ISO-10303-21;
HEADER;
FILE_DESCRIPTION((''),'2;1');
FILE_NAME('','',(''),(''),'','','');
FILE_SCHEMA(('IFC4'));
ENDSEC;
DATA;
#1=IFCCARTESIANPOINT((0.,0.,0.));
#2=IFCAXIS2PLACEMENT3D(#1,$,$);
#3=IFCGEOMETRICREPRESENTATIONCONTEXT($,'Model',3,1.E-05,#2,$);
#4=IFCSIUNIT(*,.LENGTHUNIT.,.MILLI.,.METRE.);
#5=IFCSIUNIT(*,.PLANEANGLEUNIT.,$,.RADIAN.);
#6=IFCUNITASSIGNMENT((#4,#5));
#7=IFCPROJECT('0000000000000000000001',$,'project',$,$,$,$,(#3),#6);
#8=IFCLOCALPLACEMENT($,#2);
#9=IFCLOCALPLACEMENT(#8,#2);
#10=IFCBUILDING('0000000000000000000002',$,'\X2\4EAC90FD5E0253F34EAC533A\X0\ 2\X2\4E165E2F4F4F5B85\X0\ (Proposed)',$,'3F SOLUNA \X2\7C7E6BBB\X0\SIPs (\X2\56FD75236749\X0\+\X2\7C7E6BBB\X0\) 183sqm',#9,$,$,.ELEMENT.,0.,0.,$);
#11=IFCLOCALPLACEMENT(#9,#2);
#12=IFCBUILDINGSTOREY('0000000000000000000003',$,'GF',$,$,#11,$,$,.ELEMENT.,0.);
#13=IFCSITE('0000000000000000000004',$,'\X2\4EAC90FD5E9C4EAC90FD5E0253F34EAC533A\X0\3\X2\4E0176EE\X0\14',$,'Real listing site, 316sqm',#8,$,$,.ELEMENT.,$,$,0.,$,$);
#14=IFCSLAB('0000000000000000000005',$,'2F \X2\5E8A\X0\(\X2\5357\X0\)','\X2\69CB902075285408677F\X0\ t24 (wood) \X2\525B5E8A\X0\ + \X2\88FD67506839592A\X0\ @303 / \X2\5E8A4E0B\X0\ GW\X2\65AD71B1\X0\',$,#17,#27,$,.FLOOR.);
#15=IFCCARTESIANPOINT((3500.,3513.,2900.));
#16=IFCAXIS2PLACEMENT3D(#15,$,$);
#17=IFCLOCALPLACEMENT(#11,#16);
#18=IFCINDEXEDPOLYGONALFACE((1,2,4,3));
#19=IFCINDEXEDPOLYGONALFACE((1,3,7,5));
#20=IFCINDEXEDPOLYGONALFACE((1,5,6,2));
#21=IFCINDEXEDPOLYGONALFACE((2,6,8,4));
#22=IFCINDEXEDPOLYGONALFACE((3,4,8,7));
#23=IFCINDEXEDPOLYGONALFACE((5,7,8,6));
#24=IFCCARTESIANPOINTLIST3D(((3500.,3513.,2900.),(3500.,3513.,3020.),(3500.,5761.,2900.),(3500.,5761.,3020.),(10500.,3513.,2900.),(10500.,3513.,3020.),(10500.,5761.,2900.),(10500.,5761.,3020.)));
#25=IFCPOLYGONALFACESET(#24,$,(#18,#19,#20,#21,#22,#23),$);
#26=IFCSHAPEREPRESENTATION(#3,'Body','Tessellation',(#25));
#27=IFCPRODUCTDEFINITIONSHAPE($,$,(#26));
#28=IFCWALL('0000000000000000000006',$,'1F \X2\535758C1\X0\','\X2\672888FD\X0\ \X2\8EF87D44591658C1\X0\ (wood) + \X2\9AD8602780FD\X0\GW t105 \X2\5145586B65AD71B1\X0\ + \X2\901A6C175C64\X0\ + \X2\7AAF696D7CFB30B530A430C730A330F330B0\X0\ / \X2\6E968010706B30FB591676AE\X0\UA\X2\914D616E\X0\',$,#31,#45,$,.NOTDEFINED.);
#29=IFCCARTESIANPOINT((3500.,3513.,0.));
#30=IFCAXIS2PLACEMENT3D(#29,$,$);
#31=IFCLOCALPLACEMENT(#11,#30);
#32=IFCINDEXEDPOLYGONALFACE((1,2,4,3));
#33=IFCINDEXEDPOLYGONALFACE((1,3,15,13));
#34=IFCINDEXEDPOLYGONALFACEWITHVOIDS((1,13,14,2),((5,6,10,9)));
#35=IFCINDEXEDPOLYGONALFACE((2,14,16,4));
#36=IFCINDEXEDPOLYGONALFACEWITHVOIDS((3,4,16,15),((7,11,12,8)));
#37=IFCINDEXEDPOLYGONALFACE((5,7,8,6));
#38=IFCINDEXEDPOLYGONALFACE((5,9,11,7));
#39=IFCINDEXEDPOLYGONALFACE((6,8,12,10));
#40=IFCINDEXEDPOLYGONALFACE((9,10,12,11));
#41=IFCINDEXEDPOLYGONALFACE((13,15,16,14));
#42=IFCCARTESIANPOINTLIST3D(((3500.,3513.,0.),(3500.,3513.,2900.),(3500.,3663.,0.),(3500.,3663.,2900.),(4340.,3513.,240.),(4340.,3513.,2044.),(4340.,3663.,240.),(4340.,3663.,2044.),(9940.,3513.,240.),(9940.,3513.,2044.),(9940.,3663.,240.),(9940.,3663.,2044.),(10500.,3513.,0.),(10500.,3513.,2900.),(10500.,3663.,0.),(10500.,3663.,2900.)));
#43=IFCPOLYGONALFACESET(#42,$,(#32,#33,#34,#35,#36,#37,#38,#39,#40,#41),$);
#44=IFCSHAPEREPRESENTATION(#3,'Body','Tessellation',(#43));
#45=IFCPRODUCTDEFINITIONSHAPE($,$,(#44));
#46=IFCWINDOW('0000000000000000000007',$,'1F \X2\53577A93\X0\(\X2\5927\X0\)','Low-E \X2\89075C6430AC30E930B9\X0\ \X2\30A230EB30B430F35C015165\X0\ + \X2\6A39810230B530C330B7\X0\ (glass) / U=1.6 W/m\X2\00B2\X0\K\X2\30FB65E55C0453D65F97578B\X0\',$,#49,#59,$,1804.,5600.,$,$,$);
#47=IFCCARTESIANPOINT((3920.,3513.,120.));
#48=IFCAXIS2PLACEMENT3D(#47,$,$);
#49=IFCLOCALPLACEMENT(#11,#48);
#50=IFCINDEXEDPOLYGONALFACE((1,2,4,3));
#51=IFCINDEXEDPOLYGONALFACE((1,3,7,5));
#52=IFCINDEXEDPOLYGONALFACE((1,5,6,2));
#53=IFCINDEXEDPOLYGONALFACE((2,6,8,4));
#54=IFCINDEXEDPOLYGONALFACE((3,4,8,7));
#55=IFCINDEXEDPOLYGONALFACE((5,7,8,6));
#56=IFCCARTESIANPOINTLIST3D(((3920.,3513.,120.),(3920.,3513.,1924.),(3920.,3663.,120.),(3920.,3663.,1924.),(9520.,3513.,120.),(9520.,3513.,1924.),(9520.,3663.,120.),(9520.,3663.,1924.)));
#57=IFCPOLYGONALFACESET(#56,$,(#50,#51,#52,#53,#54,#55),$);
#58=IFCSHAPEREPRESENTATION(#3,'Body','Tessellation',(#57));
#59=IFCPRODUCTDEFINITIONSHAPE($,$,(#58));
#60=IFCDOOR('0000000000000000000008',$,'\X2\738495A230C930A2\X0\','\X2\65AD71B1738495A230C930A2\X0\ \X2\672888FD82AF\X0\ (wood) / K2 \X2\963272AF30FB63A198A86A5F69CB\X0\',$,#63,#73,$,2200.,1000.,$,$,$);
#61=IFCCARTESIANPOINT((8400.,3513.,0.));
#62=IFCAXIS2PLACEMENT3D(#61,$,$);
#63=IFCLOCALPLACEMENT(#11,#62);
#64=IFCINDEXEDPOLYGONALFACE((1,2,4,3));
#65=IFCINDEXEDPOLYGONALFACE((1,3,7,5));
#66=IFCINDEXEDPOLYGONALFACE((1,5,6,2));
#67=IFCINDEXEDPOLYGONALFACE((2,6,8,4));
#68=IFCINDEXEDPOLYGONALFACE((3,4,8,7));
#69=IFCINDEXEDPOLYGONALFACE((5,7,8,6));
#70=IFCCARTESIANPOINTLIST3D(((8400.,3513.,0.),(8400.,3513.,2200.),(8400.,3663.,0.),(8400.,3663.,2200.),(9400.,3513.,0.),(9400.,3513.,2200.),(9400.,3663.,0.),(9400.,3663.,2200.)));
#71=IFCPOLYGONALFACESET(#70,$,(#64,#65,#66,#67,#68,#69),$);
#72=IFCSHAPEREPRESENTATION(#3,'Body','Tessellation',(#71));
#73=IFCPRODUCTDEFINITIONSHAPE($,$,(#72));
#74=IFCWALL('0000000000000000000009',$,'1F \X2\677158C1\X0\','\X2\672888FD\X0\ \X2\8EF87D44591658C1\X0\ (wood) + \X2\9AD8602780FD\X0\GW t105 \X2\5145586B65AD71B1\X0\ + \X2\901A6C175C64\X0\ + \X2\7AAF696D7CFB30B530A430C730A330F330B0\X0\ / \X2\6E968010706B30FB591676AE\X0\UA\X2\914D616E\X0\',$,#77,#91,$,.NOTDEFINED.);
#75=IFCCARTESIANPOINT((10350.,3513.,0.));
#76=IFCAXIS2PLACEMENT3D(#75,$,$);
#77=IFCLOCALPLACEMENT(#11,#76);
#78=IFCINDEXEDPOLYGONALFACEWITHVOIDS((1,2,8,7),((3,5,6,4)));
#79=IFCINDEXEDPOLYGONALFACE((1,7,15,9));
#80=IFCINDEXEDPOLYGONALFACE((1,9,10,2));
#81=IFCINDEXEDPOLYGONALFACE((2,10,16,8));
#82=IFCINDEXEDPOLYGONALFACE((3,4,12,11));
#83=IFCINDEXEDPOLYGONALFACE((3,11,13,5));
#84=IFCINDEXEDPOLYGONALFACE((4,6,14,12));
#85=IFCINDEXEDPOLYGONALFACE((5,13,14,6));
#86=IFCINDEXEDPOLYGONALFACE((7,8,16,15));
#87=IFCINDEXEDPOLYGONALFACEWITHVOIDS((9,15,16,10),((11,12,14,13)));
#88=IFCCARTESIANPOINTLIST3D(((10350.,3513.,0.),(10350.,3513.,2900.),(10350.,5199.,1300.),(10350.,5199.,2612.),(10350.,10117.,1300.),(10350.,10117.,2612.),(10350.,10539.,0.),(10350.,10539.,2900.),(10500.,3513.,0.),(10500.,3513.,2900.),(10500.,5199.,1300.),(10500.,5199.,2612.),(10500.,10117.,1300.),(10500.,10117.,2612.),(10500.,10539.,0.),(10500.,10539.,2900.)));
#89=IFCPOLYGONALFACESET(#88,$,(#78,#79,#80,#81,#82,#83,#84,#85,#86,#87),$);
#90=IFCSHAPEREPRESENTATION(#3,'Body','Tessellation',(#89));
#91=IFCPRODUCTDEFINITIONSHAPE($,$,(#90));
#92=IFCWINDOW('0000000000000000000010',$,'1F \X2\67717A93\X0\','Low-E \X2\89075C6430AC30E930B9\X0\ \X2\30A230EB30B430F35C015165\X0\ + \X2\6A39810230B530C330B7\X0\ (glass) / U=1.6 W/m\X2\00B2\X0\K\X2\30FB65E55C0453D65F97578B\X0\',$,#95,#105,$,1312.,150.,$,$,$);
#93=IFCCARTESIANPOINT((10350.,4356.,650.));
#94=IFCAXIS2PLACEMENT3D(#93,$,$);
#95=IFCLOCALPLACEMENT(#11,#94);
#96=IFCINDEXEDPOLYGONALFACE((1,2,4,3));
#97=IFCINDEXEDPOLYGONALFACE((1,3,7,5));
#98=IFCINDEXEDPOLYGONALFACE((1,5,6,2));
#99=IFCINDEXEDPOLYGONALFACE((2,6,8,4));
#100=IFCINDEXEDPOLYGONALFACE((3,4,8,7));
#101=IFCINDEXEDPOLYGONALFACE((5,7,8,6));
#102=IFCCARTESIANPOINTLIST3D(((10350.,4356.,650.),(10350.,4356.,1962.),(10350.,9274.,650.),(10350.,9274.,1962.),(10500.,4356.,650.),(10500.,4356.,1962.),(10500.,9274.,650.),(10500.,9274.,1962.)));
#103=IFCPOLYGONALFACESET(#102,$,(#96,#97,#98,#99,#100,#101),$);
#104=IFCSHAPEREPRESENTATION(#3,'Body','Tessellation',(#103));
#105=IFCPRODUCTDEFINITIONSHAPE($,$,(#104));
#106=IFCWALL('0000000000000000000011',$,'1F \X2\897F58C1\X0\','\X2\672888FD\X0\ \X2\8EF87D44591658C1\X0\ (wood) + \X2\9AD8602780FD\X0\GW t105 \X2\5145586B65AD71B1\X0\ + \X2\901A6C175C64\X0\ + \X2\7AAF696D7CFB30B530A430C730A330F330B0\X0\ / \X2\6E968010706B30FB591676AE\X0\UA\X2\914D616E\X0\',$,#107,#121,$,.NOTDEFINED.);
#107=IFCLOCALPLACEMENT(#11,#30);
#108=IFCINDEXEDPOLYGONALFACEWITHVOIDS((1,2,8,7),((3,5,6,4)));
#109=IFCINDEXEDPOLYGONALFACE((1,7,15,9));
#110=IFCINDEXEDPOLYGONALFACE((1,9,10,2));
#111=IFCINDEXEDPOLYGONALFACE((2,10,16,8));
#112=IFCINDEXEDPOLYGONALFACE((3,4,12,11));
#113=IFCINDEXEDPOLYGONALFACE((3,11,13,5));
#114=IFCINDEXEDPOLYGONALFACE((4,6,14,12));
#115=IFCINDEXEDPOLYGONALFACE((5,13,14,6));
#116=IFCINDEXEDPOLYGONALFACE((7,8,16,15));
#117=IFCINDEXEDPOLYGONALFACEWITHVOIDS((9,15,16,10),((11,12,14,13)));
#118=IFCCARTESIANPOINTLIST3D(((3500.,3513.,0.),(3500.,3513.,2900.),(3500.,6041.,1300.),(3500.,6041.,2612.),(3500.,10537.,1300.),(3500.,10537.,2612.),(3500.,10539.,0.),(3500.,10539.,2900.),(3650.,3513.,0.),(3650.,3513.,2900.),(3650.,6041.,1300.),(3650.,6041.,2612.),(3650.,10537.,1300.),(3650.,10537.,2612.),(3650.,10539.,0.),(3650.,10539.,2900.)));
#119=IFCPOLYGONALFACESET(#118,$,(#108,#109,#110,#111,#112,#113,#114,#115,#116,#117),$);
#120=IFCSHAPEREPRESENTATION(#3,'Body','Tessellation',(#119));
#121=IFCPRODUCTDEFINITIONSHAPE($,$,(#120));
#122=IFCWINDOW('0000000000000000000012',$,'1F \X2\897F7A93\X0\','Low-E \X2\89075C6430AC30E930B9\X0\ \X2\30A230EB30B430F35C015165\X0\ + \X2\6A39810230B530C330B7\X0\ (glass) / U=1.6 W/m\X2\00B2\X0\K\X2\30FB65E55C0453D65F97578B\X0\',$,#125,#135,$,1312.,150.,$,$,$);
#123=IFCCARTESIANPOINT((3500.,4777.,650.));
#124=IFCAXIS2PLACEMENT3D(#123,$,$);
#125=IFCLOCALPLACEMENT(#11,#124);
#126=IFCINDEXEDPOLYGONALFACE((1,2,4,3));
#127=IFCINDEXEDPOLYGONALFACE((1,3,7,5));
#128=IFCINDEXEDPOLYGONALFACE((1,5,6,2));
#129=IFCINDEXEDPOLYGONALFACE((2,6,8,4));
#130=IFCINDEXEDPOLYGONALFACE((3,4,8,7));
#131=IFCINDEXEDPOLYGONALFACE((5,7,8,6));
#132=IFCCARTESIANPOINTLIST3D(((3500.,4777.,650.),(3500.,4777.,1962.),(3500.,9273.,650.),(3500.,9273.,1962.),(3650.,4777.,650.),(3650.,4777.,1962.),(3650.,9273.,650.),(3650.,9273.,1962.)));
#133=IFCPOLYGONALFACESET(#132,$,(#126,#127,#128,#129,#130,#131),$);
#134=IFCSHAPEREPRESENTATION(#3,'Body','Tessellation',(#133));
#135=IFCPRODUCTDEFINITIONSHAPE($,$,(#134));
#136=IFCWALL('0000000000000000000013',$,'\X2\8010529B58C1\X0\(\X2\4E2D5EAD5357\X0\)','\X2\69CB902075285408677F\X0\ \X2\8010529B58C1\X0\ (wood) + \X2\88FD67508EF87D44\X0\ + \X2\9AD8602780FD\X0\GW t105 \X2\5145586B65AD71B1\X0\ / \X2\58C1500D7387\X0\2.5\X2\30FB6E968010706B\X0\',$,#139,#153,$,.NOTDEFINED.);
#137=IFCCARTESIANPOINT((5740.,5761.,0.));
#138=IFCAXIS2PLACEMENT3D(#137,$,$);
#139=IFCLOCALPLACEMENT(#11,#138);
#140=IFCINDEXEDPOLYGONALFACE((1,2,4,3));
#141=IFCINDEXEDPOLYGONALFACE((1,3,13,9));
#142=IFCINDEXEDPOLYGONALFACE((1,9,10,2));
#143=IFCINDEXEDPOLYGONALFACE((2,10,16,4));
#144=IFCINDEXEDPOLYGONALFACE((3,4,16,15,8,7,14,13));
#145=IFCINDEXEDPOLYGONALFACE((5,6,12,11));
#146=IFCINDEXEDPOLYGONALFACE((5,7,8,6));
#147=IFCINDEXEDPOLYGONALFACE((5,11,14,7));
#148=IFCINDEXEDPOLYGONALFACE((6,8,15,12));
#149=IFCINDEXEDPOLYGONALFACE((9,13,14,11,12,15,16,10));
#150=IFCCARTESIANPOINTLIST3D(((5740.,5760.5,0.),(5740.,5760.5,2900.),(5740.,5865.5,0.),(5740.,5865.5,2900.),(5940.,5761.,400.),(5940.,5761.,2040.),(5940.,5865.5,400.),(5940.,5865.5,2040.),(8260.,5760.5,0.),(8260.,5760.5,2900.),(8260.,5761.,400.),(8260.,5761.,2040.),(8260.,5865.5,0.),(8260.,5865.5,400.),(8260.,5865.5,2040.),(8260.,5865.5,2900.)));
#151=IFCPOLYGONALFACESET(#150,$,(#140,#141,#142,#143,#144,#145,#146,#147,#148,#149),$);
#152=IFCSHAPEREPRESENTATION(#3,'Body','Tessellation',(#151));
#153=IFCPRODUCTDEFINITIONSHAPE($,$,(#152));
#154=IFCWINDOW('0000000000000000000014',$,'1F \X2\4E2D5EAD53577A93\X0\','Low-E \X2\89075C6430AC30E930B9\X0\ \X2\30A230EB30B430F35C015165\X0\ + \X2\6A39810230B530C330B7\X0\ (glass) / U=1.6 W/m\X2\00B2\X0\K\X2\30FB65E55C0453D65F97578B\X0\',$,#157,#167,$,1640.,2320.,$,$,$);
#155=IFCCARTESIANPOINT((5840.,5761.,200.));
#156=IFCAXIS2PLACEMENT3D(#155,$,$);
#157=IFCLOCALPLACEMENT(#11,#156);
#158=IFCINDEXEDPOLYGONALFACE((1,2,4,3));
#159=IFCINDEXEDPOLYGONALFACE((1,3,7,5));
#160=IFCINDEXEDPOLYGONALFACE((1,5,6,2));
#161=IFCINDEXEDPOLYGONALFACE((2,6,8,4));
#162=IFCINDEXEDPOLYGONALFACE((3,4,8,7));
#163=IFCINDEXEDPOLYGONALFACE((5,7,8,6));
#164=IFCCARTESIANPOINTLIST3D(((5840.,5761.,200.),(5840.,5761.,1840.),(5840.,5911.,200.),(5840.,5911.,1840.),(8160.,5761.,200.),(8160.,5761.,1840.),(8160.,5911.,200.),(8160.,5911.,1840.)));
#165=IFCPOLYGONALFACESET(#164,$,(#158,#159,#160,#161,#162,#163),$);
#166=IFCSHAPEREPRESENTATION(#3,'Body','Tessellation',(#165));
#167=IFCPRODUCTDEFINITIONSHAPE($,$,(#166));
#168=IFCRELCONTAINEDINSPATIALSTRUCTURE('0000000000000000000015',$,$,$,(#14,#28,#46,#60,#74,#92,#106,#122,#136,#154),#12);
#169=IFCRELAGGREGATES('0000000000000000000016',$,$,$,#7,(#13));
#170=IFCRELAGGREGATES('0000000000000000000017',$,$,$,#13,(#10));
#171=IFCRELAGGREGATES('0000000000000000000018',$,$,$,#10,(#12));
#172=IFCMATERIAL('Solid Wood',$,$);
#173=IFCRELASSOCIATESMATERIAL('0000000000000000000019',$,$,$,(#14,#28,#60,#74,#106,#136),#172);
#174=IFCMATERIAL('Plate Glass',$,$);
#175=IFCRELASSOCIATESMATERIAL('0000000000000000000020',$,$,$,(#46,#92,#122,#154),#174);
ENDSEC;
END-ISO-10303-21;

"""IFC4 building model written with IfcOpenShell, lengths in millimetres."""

from ifc_helpers import new_model, si_unit, frame, frame_2d, origin, place, context, project, spatial, rectangle, extrude, material, element, fill, save


model = new_model("IFC4")

# Units and contexts
model_context = context("Model", 3, precision=1e-05, world=origin())
ifc_project = project(units=[si_unit("LENGTHUNIT", "METRE", prefix="MILLI"), si_unit("PLANEANGLEUNIT", "RADIAN")], contexts=[model_context])

# Site, building, storey
site_placement = place(None, origin())
site = spatial("IfcSite", under=ifc_project, at=site_placement, Name="京都府京都市右京区3丁目14", ObjectType="Real listing site, 316sqm", CompositionType="ELEMENT", RefElevation=0.0)
building_placement = place(site_placement, origin())
building = spatial("IfcBuilding", under=site, at=building_placement, Name="京都市右京区 2世帯住宅 (Proposed)", ObjectType="3F SOLUNA 籾殻SIPs (国産杉+籾殻) 183sqm", CompositionType="ELEMENT", ElevationOfRefHeight=0.0, ElevationOfTerrain=0.0)
storey_placement = place(building_placement, origin())
storey = spatial("IfcBuildingStorey", under=building, at=storey_placement, Name="GF", CompositionType="ELEMENT", Elevation=0.0)

# Slab
ifc_material_1 = material(Name="Solid Wood")
slab_1_placement = place(storey_placement, frame((3500.0, 3513.0, 2900.0)))
element("IfcSlab", 1, at=slab_1_placement, inside=storey, material=ifc_material_1, Name="2F 床(南)", Description="構造用合板 t24 (wood) 剛床 + 製材根太 @303 / 床下 GW断熱", PredefinedType="FLOOR", context=model_context, shape_type="SweptSolid", body=[
    extrude(rectangle(XDim=7000.0, YDim=2248.0, at=frame_2d((3500.0, 1124.0))), frame((3500.0, 3513.0, 2900.0)), (0.0, 0.0, 1.0), 120.0),
])

# Wall, openings, window, door
wall_1_placement = place(storey_placement, frame((3500.0, 3513.0, 0.0)))
wall_1 = element("IfcWall", 2, at=wall_1_placement, inside=storey, material=ifc_material_1, Name="1F 南壁", Description="木製 軸組外壁 (wood) + 高性能GW t105 充填断熱 + 通気層 + 窯業系サイディング / 準耐火・外皮UA配慮", PredefinedType="NOTDEFINED", context=model_context, shape_type="SweptSolid", body=[
    extrude(rectangle(XDim=7000.0, YDim=150.0, at=frame_2d((3500.0, 75.0))), frame((3500.0, 3513.0, 0.0)), (0.0, 0.0, 1.0), 2900.0),
])
opening_1_placement = place(storey_placement, frame((3920.0, 3513.0, 120.0)))
opening_1 = element("IfcOpeningElement", 3, at=opening_1_placement, cuts=wall_1, PredefinedType="NOTDEFINED", context=model_context, shape_type="SweptSolid", body=[
    extrude(rectangle(XDim=5600.0, YDim=150.0, at=frame_2d((2800.0, 75.0))), frame((3920.0, 3513.0, 120.0)), (0.0, 0.0, 1.0), 1804.0),
])
opening_2_placement = place(storey_placement, frame((8400.0, 3513.0, 0.0)))
opening_2 = element("IfcOpeningElement", 4, at=opening_2_placement, cuts=wall_1, PredefinedType="NOTDEFINED", context=model_context, shape_type="SweptSolid", body=[
    extrude(rectangle(XDim=1000.0, YDim=150.0, at=frame_2d((500.0, 75.0))), frame((8400.0, 3513.0, 0.0)), (0.0, 0.0, 1.0), 2200.0),
])
ifc_material_2 = material(Name="Plate Glass")
window_1_placement = place(storey_placement, frame((3920.0, 3513.0, 120.0)))
window_1 = element("IfcWindow", 5, at=window_1_placement, inside=storey, material=ifc_material_2, Name="1F 南窓(大)", Description="Low-E 複層ガラス アルゴン封入 + 樹脂サッシ (glass) / U=1.6 W/m²K・日射取得型", OverallHeight=1804.0, OverallWidth=5600.0, context=model_context, shape_type="SweptSolid", body=[
    extrude(rectangle(XDim=5600.0, YDim=150.0, at=frame_2d((2800.0, 75.0))), frame((3920.0, 3513.0, 120.0)), (0.0, 0.0, 1.0), 1804.0),
])
fill(opening_1, window_1)
door_placement = place(storey_placement, frame((8400.0, 3513.0, 0.0)))
door = element("IfcDoor", 6, at=door_placement, inside=storey, material=ifc_material_1, Name="玄関ドア", Description="断熱玄関ドア 木製芯 (wood) / K2 防犯・採風機構", OverallHeight=2200.0, OverallWidth=1000.0, context=model_context, shape_type="SweptSolid", body=[
    extrude(rectangle(XDim=1000.0, YDim=150.0, at=frame_2d((500.0, 75.0))), frame((8400.0, 3513.0, 0.0)), (0.0, 0.0, 1.0), 2200.0),
])
fill(opening_2, door)

# Walls, openings, windows
wall_2_placement = place(storey_placement, frame((10350.0, 3513.0, 0.0)))
wall_2 = element("IfcWall", 7, at=wall_2_placement, inside=storey, material=ifc_material_1, Name="1F 東壁", Description="木製 軸組外壁 (wood) + 高性能GW t105 充填断熱 + 通気層 + 窯業系サイディング / 準耐火・外皮UA配慮", PredefinedType="NOTDEFINED", context=model_context, shape_type="SweptSolid", body=[
    extrude(rectangle(XDim=150.0, YDim=7026.0, at=frame_2d((75.0, 3513.0))), frame((10350.0, 3513.0, 0.0)), (0.0, 0.0, 1.0), 2900.0),
])
opening_3_placement = place(storey_placement, frame((10350.0, 4356.0, 650.0)))
opening_3 = element("IfcOpeningElement", 8, at=opening_3_placement, cuts=wall_2, PredefinedType="NOTDEFINED", context=model_context, shape_type="SweptSolid", body=[
    extrude(rectangle(XDim=150.0, YDim=4918.0, at=frame_2d((75.0, 2459.0))), frame((10350.0, 4356.0, 650.0)), (0.0, 0.0, 1.0), 1312.0),
])
window_2_placement = place(storey_placement, frame((10350.0, 4356.0, 650.0)))
window_2 = element("IfcWindow", 9, at=window_2_placement, inside=storey, material=ifc_material_2, Name="1F 東窓", Description="Low-E 複層ガラス アルゴン封入 + 樹脂サッシ (glass) / U=1.6 W/m²K・日射取得型", OverallHeight=1312.0, OverallWidth=150.0, context=model_context, shape_type="SweptSolid", body=[
    extrude(rectangle(XDim=150.0, YDim=4918.0, at=frame_2d((75.0, 2459.0))), frame((10350.0, 4356.0, 650.0)), (0.0, 0.0, 1.0), 1312.0),
])
fill(opening_3, window_2)
wall_3_placement = place(storey_placement, frame((3500.0, 3513.0, 0.0)))
wall_3 = element("IfcWall", 10, at=wall_3_placement, inside=storey, material=ifc_material_1, Name="1F 西壁", Description="木製 軸組外壁 (wood) + 高性能GW t105 充填断熱 + 通気層 + 窯業系サイディング / 準耐火・外皮UA配慮", PredefinedType="NOTDEFINED", context=model_context, shape_type="SweptSolid", body=[
    extrude(rectangle(XDim=150.0, YDim=7026.0, at=frame_2d((75.0, 3513.0))), frame((3500.0, 3513.0, 0.0)), (0.0, 0.0, 1.0), 2900.0),
])
opening_4_placement = place(storey_placement, frame((3500.0, 4777.0, 650.0)))
opening_4 = element("IfcOpeningElement", 11, at=opening_4_placement, cuts=wall_3, PredefinedType="NOTDEFINED", context=model_context, shape_type="SweptSolid", body=[
    extrude(rectangle(XDim=150.0, YDim=4496.0, at=frame_2d((75.0, 2248.0))), frame((3500.0, 4777.0, 650.0)), (0.0, 0.0, 1.0), 1312.0),
])
window_3_placement = place(storey_placement, frame((3500.0, 4777.0, 650.0)))
window_3 = element("IfcWindow", 12, at=window_3_placement, inside=storey, material=ifc_material_2, Name="1F 西窓", Description="Low-E 複層ガラス アルゴン封入 + 樹脂サッシ (glass) / U=1.6 W/m²K・日射取得型", OverallHeight=1312.0, OverallWidth=150.0, context=model_context, shape_type="SweptSolid", body=[
    extrude(rectangle(XDim=150.0, YDim=4496.0, at=frame_2d((75.0, 2248.0))), frame((3500.0, 4777.0, 650.0)), (0.0, 0.0, 1.0), 1312.0),
])
fill(opening_4, window_3)
wall_4_placement = place(storey_placement, frame((5740.0, 5761.0, 0.0)))
wall_4 = element("IfcWall", 13, at=wall_4_placement, inside=storey, material=ifc_material_1, Name="耐力壁(中庭南)", Description="構造用合板 耐力壁 (wood) + 製材軸組 + 高性能GW t105 充填断熱 / 壁倍率2.5・準耐火", PredefinedType="NOTDEFINED", context=model_context, shape_type="SweptSolid", body=[
    extrude(rectangle(XDim=2520.0, YDim=105.0, at=frame_2d((1260.0, 52.0))), frame((5740.0, 5761.0, 0.0)), (0.0, 0.0, 1.0), 2900.0),
])
opening_5_placement = place(storey_placement, frame((5840.0, 5761.0, 200.0)))
opening_5 = element("IfcOpeningElement", 14, at=opening_5_placement, cuts=wall_4, PredefinedType="NOTDEFINED", context=model_context, shape_type="SweptSolid", body=[
    extrude(rectangle(XDim=2320.0, YDim=150.0, at=frame_2d((1160.0, 75.0))), frame((5840.0, 5761.0, 200.0)), (0.0, 0.0, 1.0), 1640.0),
])
window_4_placement = place(storey_placement, frame((5840.0, 5761.0, 200.0)))
window_4 = element("IfcWindow", 15, at=window_4_placement, inside=storey, material=ifc_material_2, Name="1F 中庭南窓", Description="Low-E 複層ガラス アルゴン封入 + 樹脂サッシ (glass) / U=1.6 W/m²K・日射取得型", OverallHeight=1640.0, OverallWidth=2320.0, context=model_context, shape_type="SweptSolid", body=[
    extrude(rectangle(XDim=2320.0, YDim=150.0, at=frame_2d((1160.0, 75.0))), frame((5840.0, 5761.0, 200.0)), (0.0, 0.0, 1.0), 1640.0),
])
fill(opening_5, window_4)

save(model, "model.ifc")
